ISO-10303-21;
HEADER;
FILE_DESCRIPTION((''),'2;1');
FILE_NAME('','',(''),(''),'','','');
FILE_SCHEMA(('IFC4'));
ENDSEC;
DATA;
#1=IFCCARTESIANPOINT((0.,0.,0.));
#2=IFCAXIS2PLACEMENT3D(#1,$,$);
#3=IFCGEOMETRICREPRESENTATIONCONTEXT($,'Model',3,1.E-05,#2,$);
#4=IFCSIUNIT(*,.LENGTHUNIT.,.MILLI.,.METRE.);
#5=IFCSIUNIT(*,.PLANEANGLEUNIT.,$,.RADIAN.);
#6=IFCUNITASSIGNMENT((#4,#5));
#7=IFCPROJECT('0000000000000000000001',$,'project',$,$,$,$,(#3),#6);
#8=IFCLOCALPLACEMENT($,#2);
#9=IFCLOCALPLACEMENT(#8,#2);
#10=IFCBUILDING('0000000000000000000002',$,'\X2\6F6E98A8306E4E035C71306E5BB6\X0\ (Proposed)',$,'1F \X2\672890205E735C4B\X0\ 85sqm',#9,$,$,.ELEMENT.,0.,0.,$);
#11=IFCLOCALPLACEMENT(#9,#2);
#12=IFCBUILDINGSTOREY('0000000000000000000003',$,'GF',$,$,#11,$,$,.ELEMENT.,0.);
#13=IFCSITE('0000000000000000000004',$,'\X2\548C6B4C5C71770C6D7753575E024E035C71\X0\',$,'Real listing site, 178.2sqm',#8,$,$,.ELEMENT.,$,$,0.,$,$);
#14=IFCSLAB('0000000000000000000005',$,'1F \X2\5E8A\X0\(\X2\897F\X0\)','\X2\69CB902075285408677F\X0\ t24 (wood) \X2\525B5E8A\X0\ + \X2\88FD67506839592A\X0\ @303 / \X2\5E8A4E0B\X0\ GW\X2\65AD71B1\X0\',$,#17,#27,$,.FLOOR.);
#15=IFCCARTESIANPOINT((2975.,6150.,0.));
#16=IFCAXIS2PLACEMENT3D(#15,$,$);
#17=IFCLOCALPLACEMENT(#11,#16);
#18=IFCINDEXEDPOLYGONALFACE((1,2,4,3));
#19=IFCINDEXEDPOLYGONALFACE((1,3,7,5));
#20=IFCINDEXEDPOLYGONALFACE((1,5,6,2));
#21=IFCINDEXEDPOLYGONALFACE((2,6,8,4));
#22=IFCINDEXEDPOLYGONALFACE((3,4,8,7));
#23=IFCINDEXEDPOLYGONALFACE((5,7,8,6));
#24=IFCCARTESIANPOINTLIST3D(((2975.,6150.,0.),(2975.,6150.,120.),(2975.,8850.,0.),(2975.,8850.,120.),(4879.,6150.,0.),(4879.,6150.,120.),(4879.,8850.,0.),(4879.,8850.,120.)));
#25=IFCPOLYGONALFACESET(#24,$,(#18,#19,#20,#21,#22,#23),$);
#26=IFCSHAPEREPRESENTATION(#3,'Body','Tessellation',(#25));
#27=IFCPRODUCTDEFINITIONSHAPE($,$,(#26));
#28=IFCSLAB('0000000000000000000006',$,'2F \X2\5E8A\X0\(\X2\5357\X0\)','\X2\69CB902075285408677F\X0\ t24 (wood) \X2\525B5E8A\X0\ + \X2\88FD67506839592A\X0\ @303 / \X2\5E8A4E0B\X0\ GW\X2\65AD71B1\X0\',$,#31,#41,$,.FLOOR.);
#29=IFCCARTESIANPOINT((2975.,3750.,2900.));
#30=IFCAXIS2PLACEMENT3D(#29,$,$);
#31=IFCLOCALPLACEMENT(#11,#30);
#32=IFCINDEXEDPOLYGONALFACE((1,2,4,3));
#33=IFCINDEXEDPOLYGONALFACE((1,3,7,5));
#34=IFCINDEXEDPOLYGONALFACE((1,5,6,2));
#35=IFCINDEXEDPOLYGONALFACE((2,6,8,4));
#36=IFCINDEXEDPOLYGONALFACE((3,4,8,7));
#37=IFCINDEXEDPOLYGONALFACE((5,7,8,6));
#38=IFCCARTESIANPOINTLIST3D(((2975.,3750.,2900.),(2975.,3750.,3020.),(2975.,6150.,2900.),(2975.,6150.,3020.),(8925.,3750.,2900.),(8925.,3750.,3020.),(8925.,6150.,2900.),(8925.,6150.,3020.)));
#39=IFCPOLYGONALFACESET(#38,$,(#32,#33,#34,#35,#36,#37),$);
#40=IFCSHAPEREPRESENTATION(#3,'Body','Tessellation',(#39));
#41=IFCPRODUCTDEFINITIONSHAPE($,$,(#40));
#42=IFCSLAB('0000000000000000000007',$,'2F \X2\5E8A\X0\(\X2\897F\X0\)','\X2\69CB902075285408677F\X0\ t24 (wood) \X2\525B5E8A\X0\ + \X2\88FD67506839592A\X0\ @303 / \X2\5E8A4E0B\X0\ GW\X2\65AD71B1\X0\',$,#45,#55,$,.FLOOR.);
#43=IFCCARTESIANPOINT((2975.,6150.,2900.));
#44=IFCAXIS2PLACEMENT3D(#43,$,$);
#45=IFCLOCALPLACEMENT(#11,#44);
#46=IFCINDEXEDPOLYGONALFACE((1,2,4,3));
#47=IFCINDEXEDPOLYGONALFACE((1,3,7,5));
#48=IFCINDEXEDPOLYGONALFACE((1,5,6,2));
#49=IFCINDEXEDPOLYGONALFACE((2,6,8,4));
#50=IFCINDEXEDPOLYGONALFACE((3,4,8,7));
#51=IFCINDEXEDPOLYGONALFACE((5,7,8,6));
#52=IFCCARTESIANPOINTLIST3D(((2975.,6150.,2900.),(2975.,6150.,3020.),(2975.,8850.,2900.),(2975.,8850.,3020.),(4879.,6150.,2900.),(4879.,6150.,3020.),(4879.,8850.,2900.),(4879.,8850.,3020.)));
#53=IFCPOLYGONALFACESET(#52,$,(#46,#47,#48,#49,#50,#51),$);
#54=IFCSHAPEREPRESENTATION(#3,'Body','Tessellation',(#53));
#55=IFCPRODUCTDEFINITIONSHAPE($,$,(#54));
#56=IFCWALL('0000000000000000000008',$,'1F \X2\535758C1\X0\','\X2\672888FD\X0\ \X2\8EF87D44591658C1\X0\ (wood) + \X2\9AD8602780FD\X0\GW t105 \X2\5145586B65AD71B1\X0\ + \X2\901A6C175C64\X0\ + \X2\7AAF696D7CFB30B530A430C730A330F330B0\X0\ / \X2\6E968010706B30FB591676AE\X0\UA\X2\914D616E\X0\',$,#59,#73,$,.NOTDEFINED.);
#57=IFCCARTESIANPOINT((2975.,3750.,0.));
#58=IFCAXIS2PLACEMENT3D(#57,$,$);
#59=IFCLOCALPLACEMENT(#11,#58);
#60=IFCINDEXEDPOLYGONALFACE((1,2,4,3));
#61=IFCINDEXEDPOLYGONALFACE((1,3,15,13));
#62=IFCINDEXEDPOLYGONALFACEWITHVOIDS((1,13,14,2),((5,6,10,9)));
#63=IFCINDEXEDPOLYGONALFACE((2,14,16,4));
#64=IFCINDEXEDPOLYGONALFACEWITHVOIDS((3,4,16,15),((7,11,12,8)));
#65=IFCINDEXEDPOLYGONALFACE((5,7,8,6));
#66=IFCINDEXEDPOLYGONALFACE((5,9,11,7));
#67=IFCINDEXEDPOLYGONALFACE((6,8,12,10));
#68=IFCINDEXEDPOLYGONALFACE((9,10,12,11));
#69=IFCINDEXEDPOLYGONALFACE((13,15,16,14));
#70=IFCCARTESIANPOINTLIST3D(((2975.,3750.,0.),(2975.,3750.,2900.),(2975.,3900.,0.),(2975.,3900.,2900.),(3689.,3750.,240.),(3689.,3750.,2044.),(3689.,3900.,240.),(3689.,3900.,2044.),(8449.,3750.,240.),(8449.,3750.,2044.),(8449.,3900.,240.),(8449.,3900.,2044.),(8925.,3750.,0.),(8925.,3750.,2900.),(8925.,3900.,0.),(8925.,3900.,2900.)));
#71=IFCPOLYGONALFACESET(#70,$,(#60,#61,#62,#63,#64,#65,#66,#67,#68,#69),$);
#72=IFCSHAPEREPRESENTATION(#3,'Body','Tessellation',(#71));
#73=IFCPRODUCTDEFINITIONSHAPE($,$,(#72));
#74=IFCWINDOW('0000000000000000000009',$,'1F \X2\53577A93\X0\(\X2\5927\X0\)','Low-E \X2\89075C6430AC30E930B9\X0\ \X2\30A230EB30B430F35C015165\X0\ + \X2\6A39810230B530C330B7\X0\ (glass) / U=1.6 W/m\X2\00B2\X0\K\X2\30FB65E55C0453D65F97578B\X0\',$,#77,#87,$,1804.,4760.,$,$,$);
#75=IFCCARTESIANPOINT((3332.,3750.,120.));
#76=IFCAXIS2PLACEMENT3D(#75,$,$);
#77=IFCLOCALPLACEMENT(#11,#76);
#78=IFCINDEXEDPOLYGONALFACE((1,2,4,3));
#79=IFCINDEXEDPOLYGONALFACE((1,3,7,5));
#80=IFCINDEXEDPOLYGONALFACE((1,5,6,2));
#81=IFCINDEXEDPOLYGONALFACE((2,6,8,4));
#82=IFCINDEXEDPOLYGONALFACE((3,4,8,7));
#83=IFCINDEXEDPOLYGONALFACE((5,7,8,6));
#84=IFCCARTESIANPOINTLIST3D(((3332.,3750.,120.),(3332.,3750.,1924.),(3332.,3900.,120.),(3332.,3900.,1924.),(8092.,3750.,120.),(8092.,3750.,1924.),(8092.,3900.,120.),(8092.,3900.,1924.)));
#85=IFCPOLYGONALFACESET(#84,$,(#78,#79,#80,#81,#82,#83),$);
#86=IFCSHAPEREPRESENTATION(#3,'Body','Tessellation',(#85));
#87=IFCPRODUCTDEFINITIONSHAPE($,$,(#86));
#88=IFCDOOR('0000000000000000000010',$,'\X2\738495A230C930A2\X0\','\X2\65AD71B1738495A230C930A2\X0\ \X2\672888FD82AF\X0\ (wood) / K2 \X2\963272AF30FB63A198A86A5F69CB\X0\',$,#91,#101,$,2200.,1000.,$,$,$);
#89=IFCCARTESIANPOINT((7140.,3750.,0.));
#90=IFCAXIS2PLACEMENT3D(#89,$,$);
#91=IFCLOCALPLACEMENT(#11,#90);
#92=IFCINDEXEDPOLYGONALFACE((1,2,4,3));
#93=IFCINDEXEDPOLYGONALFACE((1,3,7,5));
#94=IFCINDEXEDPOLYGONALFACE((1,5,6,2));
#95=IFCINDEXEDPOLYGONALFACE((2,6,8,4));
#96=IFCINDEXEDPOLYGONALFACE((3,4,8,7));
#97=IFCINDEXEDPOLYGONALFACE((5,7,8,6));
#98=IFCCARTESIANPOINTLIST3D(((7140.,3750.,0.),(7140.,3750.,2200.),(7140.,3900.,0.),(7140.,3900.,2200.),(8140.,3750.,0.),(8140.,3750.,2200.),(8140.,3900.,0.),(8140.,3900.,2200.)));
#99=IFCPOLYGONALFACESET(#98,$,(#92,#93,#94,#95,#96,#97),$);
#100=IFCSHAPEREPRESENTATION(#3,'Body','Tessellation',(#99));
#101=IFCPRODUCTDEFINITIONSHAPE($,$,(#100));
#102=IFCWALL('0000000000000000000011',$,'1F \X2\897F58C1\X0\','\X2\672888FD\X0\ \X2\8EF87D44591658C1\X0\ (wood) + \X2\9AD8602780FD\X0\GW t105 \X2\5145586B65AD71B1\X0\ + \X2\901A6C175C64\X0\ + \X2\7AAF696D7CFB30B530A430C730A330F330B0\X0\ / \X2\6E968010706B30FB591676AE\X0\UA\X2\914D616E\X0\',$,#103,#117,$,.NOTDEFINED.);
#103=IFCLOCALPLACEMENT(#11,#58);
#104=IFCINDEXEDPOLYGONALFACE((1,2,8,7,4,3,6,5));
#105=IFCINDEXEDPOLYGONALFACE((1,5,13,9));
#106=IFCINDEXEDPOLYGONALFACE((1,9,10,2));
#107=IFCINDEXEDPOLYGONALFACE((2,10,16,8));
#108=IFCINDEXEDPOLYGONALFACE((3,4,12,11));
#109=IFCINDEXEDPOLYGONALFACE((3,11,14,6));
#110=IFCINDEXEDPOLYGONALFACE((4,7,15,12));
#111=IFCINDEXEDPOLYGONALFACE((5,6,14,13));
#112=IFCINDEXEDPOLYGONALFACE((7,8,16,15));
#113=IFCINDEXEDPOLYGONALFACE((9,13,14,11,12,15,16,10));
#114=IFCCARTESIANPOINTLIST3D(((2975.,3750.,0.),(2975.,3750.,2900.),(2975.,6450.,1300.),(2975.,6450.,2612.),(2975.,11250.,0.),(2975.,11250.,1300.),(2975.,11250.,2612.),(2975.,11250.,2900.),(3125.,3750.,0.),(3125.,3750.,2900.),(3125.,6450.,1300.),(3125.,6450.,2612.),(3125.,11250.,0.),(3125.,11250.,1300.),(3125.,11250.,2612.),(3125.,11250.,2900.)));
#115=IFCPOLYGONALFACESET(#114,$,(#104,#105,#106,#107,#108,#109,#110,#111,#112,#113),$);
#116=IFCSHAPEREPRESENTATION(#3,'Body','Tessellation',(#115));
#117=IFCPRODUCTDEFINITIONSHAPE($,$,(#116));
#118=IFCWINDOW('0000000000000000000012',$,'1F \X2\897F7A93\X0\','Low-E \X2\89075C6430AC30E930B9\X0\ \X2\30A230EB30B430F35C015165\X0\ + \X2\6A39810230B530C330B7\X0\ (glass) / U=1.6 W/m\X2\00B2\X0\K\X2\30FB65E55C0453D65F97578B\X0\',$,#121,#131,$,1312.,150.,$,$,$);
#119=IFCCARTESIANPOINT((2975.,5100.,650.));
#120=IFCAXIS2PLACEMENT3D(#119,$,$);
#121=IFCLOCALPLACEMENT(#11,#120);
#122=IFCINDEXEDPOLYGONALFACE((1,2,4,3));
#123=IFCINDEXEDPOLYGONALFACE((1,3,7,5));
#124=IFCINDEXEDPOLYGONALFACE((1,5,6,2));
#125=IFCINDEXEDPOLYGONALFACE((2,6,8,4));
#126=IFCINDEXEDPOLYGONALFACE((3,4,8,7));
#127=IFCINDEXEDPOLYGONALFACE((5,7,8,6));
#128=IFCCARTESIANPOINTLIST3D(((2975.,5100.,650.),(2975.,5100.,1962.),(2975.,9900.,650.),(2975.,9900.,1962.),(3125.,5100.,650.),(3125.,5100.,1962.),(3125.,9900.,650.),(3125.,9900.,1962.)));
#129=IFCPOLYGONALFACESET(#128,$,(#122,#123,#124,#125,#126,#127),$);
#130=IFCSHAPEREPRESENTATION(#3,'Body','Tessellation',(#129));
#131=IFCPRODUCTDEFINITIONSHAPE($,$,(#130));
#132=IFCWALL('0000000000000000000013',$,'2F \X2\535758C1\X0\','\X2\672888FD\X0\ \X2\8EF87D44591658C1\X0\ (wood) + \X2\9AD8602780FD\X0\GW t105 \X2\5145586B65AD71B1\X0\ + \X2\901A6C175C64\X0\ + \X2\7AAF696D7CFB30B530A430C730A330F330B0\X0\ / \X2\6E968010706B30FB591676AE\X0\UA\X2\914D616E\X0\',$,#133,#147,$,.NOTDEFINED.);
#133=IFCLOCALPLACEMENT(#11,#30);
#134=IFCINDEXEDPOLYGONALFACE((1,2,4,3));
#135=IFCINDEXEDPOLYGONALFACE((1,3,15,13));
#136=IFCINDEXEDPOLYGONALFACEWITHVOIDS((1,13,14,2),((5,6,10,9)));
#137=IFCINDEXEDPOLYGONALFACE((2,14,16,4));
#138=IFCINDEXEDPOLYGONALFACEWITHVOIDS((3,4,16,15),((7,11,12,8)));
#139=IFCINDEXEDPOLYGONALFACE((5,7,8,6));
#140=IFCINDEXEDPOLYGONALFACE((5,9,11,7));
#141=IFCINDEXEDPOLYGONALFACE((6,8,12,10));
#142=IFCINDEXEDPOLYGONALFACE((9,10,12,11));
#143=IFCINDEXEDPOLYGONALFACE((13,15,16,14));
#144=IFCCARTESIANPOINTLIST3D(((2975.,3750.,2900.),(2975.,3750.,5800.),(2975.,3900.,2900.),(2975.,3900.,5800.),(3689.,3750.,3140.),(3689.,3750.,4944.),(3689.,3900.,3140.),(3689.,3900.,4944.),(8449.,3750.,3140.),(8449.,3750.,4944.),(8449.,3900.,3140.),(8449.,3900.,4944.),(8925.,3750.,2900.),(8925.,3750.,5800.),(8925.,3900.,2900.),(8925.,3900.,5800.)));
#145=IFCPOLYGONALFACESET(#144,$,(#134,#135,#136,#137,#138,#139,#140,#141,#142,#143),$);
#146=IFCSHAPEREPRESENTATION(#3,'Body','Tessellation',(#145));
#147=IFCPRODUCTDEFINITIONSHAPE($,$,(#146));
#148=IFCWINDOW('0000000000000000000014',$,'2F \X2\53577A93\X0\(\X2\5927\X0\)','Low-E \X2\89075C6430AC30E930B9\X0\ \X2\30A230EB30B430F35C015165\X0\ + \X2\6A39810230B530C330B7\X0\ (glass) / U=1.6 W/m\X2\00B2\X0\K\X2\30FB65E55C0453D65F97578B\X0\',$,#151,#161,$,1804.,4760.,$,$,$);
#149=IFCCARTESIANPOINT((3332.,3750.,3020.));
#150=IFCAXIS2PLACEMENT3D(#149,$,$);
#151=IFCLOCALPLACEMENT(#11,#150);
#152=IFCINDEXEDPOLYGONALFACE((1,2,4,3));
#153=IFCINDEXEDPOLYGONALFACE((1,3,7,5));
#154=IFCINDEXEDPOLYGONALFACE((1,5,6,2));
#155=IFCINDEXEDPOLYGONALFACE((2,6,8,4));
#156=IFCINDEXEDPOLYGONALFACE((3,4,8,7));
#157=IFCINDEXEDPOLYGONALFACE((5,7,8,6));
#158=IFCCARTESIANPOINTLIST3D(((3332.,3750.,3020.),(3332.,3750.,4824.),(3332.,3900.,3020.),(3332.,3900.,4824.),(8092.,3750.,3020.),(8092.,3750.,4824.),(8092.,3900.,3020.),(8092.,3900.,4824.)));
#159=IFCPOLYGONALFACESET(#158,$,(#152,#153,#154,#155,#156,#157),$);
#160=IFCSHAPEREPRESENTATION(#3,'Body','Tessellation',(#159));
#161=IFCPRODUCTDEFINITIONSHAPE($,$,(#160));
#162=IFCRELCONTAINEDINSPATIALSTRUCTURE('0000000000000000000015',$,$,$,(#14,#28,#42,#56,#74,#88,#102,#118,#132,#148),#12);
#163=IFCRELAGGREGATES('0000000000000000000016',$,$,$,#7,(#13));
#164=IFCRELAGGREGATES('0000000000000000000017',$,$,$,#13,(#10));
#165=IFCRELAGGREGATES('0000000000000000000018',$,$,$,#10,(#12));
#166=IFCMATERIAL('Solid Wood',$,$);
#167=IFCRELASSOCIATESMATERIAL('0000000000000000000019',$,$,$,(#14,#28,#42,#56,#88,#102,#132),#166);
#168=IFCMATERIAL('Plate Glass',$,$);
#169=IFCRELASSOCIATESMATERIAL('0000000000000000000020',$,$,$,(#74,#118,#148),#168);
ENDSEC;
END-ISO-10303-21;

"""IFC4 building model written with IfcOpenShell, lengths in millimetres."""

from ifc_helpers import new_model, si_unit, frame, frame_2d, origin, place, context, project, spatial, rectangle, extrude, material, element, fill, save


model = new_model("IFC4")

# Units and contexts
model_context = context("Model", 3, precision=1e-05, world=origin())
ifc_project = project(units=[si_unit("LENGTHUNIT", "METRE", prefix="MILLI"), si_unit("PLANEANGLEUNIT", "RADIAN")], contexts=[model_context])

# Site, building, storey
site_placement = place(None, origin())
site = spatial("IfcSite", under=ifc_project, at=site_placement, Name="和歌山県海南市七山", ObjectType="Real listing site, 178.2sqm", CompositionType="ELEMENT", RefElevation=0.0)
building_placement = place(site_placement, origin())
building = spatial("IfcBuilding", under=site, at=building_placement, Name="潮風の七山の家 (Proposed)", ObjectType="1F 木造平屋 85sqm", CompositionType="ELEMENT", ElevationOfRefHeight=0.0, ElevationOfTerrain=0.0)
storey_placement = place(building_placement, origin())
storey = spatial("IfcBuildingStorey", under=building, at=storey_placement, Name="GF", CompositionType="ELEMENT", Elevation=0.0)

# Slabs
ifc_material_1 = material(Name="Solid Wood")
slab_1_placement = place(storey_placement, frame((2975.0, 6150.0, 0.0)))
element("IfcSlab", 1, at=slab_1_placement, inside=storey, material=ifc_material_1, Name="1F 床(西)", Description="構造用合板 t24 (wood) 剛床 + 製材根太 @303 / 床下 GW断熱", PredefinedType="FLOOR", context=model_context, shape_type="SweptSolid", body=[
    extrude(rectangle(XDim=1904.0, YDim=2700.0, at=frame_2d((952.0, 1350.0))), frame((2975.0, 6150.0, 0.0)), (0.0, 0.0, 1.0), 120.0),
])
slab_2_placement = place(storey_placement, frame((2975.0, 3750.0, 2900.0)))
element("IfcSlab", 2, at=slab_2_placement, inside=storey, material=ifc_material_1, Name="2F 床(南)", Description="構造用合板 t24 (wood) 剛床 + 製材根太 @303 / 床下 GW断熱", PredefinedType="FLOOR", context=model_context, shape_type="SweptSolid", body=[
    extrude(rectangle(XDim=5950.0, YDim=2400.0, at=frame_2d((2975.0, 1200.0))), frame((2975.0, 3750.0, 2900.0)), (0.0, 0.0, 1.0), 120.0),
])
slab_3_placement = place(storey_placement, frame((2975.0, 6150.0, 2900.0)))
element("IfcSlab", 3, at=slab_3_placement, inside=storey, material=ifc_material_1, Name="2F 床(西)", Description="構造用合板 t24 (wood) 剛床 + 製材根太 @303 / 床下 GW断熱", PredefinedType="FLOOR", context=model_context, shape_type="SweptSolid", body=[
    extrude(rectangle(XDim=1904.0, YDim=2700.0, at=frame_2d((952.0, 1350.0))), frame((2975.0, 6150.0, 2900.0)), (0.0, 0.0, 1.0), 120.0),
])

# Wall, openings, window, door
wall_1_placement = place(storey_placement, frame((2975.0, 3750.0, 0.0)))
wall_1 = element("IfcWall", 4, at=wall_1_placement, inside=storey, material=ifc_material_1, Name="1F 南壁", Description="木製 軸組外壁 (wood) + 高性能GW t105 充填断熱 + 通気層 + 窯業系サイディング / 準耐火・外皮UA配慮", PredefinedType="NOTDEFINED", context=model_context, shape_type="SweptSolid", body=[
    extrude(rectangle(XDim=5950.0, YDim=150.0, at=frame_2d((2975.0, 75.0))), frame((2975.0, 3750.0, 0.0)), (0.0, 0.0, 1.0), 2900.0),
])
opening_1_placement = place(storey_placement, frame((3332.0, 3750.0, 120.0)))
opening_1 = element("IfcOpeningElement", 5, at=opening_1_placement, cuts=wall_1, PredefinedType="NOTDEFINED", context=model_context, shape_type="SweptSolid", body=[
    extrude(rectangle(XDim=4760.0, YDim=150.0, at=frame_2d((2380.0, 75.0))), frame((3332.0, 3750.0, 120.0)), (0.0, 0.0, 1.0), 1804.0),
])
opening_2_placement = place(storey_placement, frame((7140.0, 3750.0, 0.0)))
opening_2 = element("IfcOpeningElement", 6, at=opening_2_placement, cuts=wall_1, PredefinedType="NOTDEFINED", context=model_context, shape_type="SweptSolid", body=[
    extrude(rectangle(XDim=1000.0, YDim=150.0, at=frame_2d((500.0, 75.0))), frame((7140.0, 3750.0, 0.0)), (0.0, 0.0, 1.0), 2200.0),
])
ifc_material_2 = material(Name="Plate Glass")
window_1_placement = place(storey_placement, frame((3332.0, 3750.0, 120.0)))
window_1 = element("IfcWindow", 7, at=window_1_placement, inside=storey, material=ifc_material_2, Name="1F 南窓(大)", Description="Low-E 複層ガラス アルゴン封入 + 樹脂サッシ (glass) / U=1.6 W/m²K・日射取得型", OverallHeight=1804.0, OverallWidth=4760.0, context=model_context, shape_type="SweptSolid", body=[
    extrude(rectangle(XDim=4760.0, YDim=150.0, at=frame_2d((2380.0, 75.0))), frame((3332.0, 3750.0, 120.0)), (0.0, 0.0, 1.0), 1804.0),
])
fill(opening_1, window_1)
door_placement = place(storey_placement, frame((7140.0, 3750.0, 0.0)))
door = element("IfcDoor", 8, at=door_placement, inside=storey, material=ifc_material_1, Name="玄関ドア", Description="断熱玄関ドア 木製芯 (wood) / K2 防犯・採風機構", OverallHeight=2200.0, OverallWidth=1000.0, context=model_context, shape_type="SweptSolid", body=[
    extrude(rectangle(XDim=1000.0, YDim=150.0, at=frame_2d((500.0, 75.0))), frame((7140.0, 3750.0, 0.0)), (0.0, 0.0, 1.0), 2200.0),
])
fill(opening_2, door)

# Walls, openings, windows
wall_2_placement = place(storey_placement, frame((2975.0, 3750.0, 0.0)))
wall_2 = element("IfcWall", 9, at=wall_2_placement, inside=storey, material=ifc_material_1, Name="1F 西壁", Description="木製 軸組外壁 (wood) + 高性能GW t105 充填断熱 + 通気層 + 窯業系サイディング / 準耐火・外皮UA配慮", PredefinedType="NOTDEFINED", context=model_context, shape_type="SweptSolid", body=[
    extrude(rectangle(XDim=150.0, YDim=7500.0, at=frame_2d((75.0, 3750.0))), frame((2975.0, 3750.0, 0.0)), (0.0, 0.0, 1.0), 2900.0),
])
opening_3_placement = place(storey_placement, frame((2975.0, 5100.0, 650.0)))
opening_3 = element("IfcOpeningElement", 10, at=opening_3_placement, cuts=wall_2, PredefinedType="NOTDEFINED", context=model_context, shape_type="SweptSolid", body=[
    extrude(rectangle(XDim=150.0, YDim=4800.0, at=frame_2d((75.0, 2400.0))), frame((2975.0, 5100.0, 650.0)), (0.0, 0.0, 1.0), 1312.0),
])
window_2_placement = place(storey_placement, frame((2975.0, 5100.0, 650.0)))
window_2 = element("IfcWindow", 11, at=window_2_placement, inside=storey, material=ifc_material_2, Name="1F 西窓", Description="Low-E 複層ガラス アルゴン封入 + 樹脂サッシ (glass) / U=1.6 W/m²K・日射取得型", OverallHeight=1312.0, OverallWidth=150.0, context=model_context, shape_type="SweptSolid", body=[
    extrude(rectangle(XDim=150.0, YDim=4800.0, at=frame_2d((75.0, 2400.0))), frame((2975.0, 5100.0, 650.0)), (0.0, 0.0, 1.0), 1312.0),
])
fill(opening_3, window_2)
wall_3_placement = place(storey_placement, frame((2975.0, 3750.0, 2900.0)))
wall_3 = element("IfcWall", 12, at=wall_3_placement, inside=storey, material=ifc_material_1, Name="2F 南壁", Description="木製 軸組外壁 (wood) + 高性能GW t105 充填断熱 + 通気層 + 窯業系サイディング / 準耐火・外皮UA配慮", PredefinedType="NOTDEFINED", context=model_context, shape_type="SweptSolid", body=[
    extrude(rectangle(XDim=5950.0, YDim=150.0, at=frame_2d((2975.0, 75.0))), frame((2975.0, 3750.0, 2900.0)), (0.0, 0.0, 1.0), 2900.0),
])
opening_4_placement = place(storey_placement, frame((3332.0, 3750.0, 3020.0)))
opening_4 = element("IfcOpeningElement", 13, at=opening_4_placement, cuts=wall_3, PredefinedType="NOTDEFINED", context=model_context, shape_type="SweptSolid", body=[
    extrude(rectangle(XDim=4760.0, YDim=150.0, at=frame_2d((2380.0, 75.0))), frame((3332.0, 3750.0, 3020.0)), (0.0, 0.0, 1.0), 1804.0),
])
window_3_placement = place(storey_placement, frame((3332.0, 3750.0, 3020.0)))
window_3 = element("IfcWindow", 14, at=window_3_placement, inside=storey, material=ifc_material_2, Name="2F 南窓(大)", Description="Low-E 複層ガラス アルゴン封入 + 樹脂サッシ (glass) / U=1.6 W/m²K・日射取得型", OverallHeight=1804.0, OverallWidth=4760.0, context=model_context, shape_type="SweptSolid", body=[
    extrude(rectangle(XDim=4760.0, YDim=150.0, at=frame_2d((2380.0, 75.0))), frame((3332.0, 3750.0, 3020.0)), (0.0, 0.0, 1.0), 1804.0),
])
fill(opening_4, window_3)

save(model, "model.ifc")
